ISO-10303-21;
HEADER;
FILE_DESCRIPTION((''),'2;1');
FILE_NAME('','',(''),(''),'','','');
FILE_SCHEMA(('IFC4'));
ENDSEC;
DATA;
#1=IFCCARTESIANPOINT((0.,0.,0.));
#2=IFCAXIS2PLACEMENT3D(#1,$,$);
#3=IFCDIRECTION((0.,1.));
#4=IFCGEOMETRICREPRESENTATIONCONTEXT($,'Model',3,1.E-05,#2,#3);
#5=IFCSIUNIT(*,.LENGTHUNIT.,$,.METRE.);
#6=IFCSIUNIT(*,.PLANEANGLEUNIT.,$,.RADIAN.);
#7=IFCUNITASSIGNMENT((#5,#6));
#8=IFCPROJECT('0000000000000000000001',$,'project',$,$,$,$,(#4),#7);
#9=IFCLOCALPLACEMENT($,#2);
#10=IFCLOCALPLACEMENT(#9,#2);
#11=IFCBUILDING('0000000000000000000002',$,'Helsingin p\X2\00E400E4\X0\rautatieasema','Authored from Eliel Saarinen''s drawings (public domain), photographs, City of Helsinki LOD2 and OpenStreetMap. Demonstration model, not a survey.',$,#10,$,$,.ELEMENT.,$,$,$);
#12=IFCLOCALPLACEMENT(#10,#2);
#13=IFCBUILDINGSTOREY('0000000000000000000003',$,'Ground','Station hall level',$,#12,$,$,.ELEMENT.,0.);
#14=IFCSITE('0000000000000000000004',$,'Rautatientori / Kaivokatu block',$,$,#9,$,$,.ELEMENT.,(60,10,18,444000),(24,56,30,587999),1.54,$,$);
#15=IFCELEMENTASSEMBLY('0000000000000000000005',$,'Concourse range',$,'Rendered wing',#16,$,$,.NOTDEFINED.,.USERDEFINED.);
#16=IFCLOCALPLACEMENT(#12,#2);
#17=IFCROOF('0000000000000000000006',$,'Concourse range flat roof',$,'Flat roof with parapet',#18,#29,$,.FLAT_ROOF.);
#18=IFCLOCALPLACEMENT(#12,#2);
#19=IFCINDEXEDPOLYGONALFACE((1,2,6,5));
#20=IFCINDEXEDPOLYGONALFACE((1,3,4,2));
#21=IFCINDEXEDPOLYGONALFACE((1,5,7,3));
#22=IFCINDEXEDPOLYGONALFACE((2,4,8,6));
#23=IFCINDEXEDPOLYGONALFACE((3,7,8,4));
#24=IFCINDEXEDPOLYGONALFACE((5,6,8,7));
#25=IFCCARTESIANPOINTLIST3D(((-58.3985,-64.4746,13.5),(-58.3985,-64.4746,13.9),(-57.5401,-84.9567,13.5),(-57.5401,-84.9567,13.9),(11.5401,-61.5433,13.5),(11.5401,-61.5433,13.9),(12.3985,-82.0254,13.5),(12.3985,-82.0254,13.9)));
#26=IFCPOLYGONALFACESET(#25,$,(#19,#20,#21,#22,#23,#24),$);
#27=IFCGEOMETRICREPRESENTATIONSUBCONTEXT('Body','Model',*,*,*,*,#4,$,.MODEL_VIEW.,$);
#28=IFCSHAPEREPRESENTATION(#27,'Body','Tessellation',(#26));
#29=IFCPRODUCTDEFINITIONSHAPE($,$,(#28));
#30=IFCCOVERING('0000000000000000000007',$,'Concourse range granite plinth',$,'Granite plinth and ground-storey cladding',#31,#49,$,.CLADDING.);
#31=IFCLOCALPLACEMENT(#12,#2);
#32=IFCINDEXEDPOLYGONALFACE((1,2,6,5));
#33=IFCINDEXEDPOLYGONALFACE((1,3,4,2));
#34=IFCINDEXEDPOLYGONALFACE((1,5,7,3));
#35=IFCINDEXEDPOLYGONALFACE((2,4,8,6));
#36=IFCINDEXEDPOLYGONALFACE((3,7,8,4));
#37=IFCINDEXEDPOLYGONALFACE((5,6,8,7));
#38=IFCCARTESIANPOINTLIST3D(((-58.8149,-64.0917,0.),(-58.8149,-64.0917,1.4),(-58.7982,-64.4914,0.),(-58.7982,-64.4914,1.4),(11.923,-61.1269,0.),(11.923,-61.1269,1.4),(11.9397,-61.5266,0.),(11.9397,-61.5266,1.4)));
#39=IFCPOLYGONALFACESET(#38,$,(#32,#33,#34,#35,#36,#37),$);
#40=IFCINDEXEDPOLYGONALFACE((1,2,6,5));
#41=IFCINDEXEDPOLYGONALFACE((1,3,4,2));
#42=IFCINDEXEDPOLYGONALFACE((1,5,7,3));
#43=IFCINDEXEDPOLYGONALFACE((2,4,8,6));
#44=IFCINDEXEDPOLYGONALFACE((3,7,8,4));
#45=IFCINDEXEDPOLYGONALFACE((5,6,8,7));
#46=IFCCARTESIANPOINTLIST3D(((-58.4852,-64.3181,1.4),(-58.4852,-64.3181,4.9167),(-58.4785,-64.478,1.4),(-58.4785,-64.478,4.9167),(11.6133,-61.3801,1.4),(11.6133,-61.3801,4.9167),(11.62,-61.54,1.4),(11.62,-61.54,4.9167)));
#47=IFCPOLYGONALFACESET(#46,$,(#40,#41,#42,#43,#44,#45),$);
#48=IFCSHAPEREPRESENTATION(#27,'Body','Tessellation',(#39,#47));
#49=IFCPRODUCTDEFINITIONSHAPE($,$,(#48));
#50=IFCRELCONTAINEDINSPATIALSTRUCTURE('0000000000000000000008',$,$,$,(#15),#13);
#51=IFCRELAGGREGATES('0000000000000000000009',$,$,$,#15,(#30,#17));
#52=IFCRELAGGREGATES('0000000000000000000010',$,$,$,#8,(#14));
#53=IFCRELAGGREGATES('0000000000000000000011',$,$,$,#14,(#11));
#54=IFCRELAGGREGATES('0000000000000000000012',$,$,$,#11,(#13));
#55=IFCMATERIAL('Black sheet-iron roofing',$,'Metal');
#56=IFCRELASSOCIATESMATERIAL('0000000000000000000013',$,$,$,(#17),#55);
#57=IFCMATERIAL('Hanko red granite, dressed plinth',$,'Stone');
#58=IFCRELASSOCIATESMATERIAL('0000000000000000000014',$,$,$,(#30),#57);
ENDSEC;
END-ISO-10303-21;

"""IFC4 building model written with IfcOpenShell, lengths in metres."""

from ifc_helpers import new_model, si_unit, direction, frame, frame_2d, origin, place, context, subcontext, project, spatial, rectangle, extrude, material, element, aggregate, save


model = new_model("IFC4")

# Units and contexts
model_context = context("Model", 3, precision=1e-05, world=origin(), true_north=direction((0.0, 1.0)))
body_context = subcontext(model_context, "Body", "Model", "MODEL_VIEW")
ifc_project = project(units=[si_unit("LENGTHUNIT", "METRE"), si_unit("PLANEANGLEUNIT", "RADIAN")], contexts=[model_context])

# Site, building, storey
site_placement = place(None, origin())
site = spatial("IfcSite", under=ifc_project, at=site_placement, Name="Rautatientori / Kaivokatu block", CompositionType="ELEMENT", RefLatitude=(60, 10, 18, 444000), RefLongitude=(24, 56, 30, 587999), RefElevation=1.54)
building_placement = place(site_placement, origin())
building = spatial("IfcBuilding", under=site, at=building_placement, Name="Helsingin päärautatieasema", Description="Authored from Eliel Saarinen's drawings (public domain), photographs, City of Helsinki LOD2 and OpenStreetMap. Demonstration model, not a survey.", CompositionType="ELEMENT")
storey_placement = place(building_placement, origin())
storey = spatial("IfcBuildingStorey", under=building, at=storey_placement, Name="Ground", Description="Station hall level", CompositionType="ELEMENT", Elevation=0.0)

# Element assembly
assembly_1_placement = place(building_placement, origin())
assembly_1 = element("IfcElementAssembly", 1, at=assembly_1_placement, inside=storey, Name="Concourse range", ObjectType="Rendered wing", AssemblyPlace="NOTDEFINED", PredefinedType="USERDEFINED")
ifc_material_1 = material(Name="Hanko red granite, dressed plinth", Category="Stone")

# Roof
ifc_material_2 = material(Name="Black sheet-iron roofing", Category="Metal")
roof_placement = place(building_placement, origin())
roof = element("IfcRoof", 2, at=roof_placement, material=ifc_material_2, Name="Concourse range flat roof", ObjectType="Flat roof with parapet", PredefinedType="FLAT_ROOF", context=body_context, shape_type="SweptSolid", body=[
    extrude(rectangle(XDim=70.0, YDim=20.5, at=frame_2d((0.0, 0.0), x_axis=(0.999123, 0.041876))), frame((-23.0, -73.25, 13.5)), (0.0, 0.0, 1.0), 0.4),
])

# Covering
covering_placement = place(building_placement, origin())
covering = element("IfcCovering", 3, at=covering_placement, material=ifc_material_1, Name="Concourse range granite plinth", ObjectType="Granite plinth and ground-storey cladding", PredefinedType="CLADDING", context=body_context, shape_type="SweptSolid", body=[
    extrude(rectangle(XDim=70.8, YDim=0.4, at=frame_2d((0.0, 0.0), x_axis=(-0.999123, -0.041876))), frame((-23.4376, -62.8092, 0.0)), (0.0, 0.0, 1.0), 1.4),
    extrude(rectangle(XDim=70.16, YDim=0.16, at=frame_2d((0.0, 0.0), x_axis=(-0.999123, -0.041876))), frame((-23.4326, -62.9291, 1.4)), (0.0, 0.0, 1.0), 3.5167),
])
aggregate(assembly_1, [covering, roof])

save(model, "model.ifc")
